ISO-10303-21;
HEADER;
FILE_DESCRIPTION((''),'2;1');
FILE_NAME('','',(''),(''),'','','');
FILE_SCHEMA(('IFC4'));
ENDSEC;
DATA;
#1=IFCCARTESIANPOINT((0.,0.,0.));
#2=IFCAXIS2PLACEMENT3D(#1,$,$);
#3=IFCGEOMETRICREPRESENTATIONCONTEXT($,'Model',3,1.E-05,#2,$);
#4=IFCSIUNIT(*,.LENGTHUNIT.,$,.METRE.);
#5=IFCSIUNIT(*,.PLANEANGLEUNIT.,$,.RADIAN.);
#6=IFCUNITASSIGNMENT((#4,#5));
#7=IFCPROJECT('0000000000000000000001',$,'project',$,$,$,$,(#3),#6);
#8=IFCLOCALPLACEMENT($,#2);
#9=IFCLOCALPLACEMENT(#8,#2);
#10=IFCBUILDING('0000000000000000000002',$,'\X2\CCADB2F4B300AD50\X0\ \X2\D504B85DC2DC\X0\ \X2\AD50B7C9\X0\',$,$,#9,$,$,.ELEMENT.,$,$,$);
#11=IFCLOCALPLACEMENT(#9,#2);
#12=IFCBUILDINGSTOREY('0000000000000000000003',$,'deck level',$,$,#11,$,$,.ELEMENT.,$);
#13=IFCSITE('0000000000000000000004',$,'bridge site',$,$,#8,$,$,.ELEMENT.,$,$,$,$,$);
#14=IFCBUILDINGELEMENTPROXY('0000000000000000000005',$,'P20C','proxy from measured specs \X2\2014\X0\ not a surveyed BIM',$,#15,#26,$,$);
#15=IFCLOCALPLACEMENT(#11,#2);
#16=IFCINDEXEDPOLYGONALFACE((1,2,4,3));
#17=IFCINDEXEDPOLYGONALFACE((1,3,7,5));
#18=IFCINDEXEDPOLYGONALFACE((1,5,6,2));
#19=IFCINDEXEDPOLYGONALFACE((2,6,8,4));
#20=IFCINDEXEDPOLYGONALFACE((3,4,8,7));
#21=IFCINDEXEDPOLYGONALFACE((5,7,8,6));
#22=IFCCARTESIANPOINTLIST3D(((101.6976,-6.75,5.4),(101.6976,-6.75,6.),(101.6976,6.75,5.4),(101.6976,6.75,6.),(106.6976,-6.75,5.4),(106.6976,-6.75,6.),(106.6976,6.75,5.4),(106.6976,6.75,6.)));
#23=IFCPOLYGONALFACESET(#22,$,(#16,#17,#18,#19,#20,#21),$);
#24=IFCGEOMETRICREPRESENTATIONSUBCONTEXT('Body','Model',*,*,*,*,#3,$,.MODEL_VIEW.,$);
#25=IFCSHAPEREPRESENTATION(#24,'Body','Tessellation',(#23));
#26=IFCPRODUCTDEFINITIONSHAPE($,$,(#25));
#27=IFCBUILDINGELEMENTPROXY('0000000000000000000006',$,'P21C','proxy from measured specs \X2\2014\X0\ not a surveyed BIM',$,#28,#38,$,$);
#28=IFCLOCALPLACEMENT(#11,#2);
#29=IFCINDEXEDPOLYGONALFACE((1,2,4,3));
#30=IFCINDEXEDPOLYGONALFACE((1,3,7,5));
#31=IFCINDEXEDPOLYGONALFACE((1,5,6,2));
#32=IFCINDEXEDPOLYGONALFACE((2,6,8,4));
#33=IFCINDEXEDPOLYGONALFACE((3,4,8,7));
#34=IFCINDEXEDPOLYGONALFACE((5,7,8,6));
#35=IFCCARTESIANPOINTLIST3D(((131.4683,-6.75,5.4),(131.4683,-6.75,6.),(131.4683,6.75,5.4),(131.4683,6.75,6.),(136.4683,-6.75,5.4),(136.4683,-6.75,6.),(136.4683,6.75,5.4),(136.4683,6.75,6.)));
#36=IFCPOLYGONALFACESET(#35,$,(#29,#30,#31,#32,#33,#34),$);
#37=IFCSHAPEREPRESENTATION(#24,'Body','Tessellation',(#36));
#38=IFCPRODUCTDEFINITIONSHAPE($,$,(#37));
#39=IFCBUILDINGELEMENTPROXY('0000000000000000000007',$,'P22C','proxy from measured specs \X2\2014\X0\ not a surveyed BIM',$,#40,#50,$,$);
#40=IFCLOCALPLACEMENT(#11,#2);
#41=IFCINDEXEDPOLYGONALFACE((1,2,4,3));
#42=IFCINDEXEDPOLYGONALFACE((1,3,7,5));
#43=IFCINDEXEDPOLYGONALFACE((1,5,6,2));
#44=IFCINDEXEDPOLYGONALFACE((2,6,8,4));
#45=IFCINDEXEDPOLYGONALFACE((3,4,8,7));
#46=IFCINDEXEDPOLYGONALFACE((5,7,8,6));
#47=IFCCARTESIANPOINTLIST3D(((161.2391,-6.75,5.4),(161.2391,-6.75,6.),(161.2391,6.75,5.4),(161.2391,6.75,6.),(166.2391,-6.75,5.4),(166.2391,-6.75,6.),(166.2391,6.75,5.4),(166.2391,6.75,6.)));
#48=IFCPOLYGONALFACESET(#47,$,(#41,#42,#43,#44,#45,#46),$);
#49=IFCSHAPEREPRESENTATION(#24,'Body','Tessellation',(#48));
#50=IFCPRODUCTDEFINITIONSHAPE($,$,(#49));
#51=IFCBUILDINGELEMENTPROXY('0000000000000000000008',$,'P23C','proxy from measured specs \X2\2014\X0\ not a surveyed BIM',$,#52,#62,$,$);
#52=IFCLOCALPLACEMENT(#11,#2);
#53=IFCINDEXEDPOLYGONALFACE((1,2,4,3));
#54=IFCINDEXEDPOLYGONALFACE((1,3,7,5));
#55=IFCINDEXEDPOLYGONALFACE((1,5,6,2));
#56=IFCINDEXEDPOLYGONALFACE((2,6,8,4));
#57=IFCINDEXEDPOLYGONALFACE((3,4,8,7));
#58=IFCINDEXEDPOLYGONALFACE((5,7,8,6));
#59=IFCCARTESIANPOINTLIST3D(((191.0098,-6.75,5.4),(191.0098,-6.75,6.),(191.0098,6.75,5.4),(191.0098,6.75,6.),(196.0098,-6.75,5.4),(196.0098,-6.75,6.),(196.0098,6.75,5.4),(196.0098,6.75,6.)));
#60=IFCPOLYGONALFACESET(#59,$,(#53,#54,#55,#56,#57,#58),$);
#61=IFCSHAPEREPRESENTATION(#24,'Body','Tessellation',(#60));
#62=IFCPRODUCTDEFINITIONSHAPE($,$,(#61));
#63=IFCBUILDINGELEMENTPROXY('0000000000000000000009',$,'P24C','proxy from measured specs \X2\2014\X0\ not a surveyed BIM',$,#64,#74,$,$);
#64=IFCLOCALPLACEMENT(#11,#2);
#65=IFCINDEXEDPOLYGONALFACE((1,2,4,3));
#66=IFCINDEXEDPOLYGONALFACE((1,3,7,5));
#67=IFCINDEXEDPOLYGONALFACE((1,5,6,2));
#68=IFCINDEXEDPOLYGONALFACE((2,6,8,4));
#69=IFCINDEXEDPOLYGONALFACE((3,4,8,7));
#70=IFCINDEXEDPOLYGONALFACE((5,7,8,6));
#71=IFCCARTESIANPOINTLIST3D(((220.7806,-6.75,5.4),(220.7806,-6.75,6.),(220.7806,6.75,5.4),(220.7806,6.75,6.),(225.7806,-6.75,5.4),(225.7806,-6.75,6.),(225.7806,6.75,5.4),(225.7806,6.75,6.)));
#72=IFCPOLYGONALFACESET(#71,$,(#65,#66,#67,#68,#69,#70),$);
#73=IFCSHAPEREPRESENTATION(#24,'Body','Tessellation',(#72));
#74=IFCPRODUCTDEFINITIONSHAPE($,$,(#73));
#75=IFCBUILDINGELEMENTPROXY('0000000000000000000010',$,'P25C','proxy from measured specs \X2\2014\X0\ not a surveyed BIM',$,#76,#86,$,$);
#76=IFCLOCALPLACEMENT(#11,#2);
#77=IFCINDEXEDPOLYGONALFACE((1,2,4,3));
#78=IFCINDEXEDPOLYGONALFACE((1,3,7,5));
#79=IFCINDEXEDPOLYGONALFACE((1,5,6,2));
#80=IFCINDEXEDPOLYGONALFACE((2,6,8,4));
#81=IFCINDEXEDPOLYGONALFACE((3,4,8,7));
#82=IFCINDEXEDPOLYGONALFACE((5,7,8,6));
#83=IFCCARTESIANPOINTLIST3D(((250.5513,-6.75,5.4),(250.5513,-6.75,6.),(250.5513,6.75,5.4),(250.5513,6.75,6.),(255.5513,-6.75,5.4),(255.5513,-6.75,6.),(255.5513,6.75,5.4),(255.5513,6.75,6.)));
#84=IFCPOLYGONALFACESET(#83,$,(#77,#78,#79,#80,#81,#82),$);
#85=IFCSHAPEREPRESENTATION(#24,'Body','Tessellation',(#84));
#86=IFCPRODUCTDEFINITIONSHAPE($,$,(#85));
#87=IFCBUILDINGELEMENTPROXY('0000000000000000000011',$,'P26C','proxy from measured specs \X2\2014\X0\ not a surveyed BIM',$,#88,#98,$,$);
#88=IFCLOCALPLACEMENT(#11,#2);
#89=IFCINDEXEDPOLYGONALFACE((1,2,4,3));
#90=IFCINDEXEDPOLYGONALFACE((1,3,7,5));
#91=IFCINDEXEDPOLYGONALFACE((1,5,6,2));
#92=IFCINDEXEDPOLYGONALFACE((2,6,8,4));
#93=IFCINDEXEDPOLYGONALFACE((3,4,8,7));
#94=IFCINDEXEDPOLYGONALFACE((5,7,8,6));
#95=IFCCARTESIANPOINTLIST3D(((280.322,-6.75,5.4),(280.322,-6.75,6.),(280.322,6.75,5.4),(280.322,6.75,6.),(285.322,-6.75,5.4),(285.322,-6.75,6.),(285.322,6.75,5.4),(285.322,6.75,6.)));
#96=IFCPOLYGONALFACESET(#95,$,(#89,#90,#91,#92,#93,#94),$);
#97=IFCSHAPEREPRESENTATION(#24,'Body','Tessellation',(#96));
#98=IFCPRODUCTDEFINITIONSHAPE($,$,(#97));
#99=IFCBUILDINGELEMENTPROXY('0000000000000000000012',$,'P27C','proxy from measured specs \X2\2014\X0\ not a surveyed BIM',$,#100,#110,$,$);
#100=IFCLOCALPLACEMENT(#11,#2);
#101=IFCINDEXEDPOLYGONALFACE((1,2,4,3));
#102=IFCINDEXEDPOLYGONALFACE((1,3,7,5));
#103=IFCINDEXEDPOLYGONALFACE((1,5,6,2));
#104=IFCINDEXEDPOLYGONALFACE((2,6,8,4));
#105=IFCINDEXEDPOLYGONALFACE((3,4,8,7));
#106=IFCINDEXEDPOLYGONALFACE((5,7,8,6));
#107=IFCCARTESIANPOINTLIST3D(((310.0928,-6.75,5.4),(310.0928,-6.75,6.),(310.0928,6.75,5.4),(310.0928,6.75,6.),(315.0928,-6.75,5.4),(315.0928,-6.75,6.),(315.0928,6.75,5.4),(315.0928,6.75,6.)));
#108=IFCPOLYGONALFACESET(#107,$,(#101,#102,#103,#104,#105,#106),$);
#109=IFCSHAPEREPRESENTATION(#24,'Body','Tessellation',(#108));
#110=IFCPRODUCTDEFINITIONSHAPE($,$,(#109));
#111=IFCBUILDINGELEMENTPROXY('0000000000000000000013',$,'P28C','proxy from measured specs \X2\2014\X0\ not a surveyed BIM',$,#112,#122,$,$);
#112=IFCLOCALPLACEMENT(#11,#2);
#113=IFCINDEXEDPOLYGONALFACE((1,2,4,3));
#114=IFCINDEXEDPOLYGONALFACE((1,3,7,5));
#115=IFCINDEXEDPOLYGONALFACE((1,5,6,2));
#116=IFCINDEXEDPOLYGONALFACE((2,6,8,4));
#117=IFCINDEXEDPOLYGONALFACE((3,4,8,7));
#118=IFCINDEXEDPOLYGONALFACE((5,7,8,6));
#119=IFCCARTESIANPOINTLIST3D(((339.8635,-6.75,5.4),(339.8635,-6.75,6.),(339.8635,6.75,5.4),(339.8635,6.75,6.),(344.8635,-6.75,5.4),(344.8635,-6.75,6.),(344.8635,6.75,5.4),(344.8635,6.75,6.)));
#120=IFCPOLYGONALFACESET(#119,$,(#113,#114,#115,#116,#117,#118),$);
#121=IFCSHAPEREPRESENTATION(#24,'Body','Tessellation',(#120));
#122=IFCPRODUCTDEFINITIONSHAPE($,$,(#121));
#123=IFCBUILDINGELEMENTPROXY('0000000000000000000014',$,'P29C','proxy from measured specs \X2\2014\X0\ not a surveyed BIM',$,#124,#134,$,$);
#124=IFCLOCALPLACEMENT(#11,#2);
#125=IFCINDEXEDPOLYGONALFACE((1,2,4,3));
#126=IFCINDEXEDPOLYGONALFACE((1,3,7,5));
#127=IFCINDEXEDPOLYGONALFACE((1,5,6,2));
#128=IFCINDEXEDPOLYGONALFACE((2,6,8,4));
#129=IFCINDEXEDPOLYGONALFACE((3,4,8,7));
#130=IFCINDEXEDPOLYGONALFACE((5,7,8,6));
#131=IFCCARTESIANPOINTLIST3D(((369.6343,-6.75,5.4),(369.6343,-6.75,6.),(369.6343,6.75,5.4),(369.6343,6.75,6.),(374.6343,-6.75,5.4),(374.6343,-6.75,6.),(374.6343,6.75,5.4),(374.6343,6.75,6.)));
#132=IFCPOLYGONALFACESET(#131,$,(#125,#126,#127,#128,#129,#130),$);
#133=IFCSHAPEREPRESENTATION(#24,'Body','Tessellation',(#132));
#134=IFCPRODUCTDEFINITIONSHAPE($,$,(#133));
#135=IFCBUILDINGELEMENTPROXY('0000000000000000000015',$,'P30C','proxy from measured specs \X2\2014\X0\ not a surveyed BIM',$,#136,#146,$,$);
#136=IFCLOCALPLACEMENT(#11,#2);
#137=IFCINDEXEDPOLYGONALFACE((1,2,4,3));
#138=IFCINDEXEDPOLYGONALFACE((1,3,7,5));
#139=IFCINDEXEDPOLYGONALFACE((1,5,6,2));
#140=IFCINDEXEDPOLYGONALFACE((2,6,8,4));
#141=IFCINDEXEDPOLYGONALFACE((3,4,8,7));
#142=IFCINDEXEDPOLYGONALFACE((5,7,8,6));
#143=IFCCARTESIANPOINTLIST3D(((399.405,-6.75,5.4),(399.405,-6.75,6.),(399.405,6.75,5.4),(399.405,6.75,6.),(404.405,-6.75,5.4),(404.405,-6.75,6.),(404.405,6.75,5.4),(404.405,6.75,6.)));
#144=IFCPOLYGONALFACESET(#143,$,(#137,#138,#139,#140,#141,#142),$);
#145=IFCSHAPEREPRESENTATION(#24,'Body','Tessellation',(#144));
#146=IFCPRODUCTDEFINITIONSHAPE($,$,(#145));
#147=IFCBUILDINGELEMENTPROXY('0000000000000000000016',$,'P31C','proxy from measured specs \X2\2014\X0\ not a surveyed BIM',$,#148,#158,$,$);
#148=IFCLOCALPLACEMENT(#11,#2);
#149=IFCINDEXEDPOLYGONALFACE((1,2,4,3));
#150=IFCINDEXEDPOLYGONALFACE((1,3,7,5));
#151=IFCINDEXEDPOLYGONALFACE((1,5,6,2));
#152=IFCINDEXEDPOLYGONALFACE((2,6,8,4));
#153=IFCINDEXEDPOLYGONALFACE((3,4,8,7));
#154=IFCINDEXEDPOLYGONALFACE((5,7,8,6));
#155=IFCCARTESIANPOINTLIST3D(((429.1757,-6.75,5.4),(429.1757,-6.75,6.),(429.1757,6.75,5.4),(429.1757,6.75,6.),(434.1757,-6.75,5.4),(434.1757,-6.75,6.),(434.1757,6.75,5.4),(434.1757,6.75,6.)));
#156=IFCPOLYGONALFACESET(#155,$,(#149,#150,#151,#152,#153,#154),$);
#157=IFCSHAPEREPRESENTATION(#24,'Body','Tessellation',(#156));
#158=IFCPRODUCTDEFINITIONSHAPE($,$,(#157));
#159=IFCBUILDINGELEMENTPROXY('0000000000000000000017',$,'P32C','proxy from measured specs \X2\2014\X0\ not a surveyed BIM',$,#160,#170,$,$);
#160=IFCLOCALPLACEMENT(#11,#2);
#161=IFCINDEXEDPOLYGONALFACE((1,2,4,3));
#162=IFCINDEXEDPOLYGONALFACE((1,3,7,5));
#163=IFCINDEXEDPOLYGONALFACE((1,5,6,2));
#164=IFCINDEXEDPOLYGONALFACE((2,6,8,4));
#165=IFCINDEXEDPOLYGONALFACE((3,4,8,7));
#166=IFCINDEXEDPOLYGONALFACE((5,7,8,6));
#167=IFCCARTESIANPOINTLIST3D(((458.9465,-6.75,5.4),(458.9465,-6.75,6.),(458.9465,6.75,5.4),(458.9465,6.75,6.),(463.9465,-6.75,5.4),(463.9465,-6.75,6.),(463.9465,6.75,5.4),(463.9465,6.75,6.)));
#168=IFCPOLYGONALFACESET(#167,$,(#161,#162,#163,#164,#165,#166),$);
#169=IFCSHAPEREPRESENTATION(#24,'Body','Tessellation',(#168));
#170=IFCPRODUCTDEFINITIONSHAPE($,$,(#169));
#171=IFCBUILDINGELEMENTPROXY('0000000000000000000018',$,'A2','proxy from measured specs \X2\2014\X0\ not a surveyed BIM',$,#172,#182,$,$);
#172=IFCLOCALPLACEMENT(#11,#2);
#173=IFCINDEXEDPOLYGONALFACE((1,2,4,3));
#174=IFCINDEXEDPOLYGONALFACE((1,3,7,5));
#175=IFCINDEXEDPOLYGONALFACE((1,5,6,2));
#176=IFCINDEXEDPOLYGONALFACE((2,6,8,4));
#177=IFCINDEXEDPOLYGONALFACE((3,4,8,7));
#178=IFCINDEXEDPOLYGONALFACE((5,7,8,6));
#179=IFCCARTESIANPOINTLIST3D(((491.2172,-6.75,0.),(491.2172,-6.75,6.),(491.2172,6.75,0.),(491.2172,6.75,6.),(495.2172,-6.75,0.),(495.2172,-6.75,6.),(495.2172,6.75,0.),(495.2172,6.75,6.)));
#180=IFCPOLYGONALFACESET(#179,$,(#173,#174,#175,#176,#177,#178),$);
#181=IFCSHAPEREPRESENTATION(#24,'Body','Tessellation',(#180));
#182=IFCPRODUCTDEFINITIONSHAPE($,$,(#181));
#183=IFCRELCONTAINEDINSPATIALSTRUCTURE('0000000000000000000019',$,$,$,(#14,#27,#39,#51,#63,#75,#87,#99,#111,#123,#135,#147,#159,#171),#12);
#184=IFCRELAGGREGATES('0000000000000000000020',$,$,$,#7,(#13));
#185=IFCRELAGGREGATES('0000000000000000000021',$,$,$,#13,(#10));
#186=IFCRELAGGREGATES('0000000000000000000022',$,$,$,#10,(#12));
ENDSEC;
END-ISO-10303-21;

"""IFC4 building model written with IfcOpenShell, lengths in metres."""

from ifc_helpers import new_model, si_unit, frame, origin, origin_2d, place, context, subcontext, project, spatial, rectangle, extrude, element, save


model = new_model("IFC4")

# Units and contexts
model_context = context("Model", 3, precision=1e-05, world=origin())
body_context = subcontext(model_context, "Body", "Model", "MODEL_VIEW")
ifc_project = project(units=[si_unit("LENGTHUNIT", "METRE"), si_unit("PLANEANGLEUNIT", "RADIAN")], contexts=[model_context])

# Site, building, storey
site_placement = place(None, origin())
site = spatial("IfcSite", under=ifc_project, at=site_placement, Name="bridge site", CompositionType="ELEMENT")
building_placement = place(site_placement, origin())
building = spatial("IfcBuilding", under=site, at=building_placement, Name="청담대교 프록시 교량", CompositionType="ELEMENT")
storey_placement = place(building_placement, origin())
storey = spatial("IfcBuildingStorey", under=building, at=storey_placement, Name="deck level", CompositionType="ELEMENT")

# Building element proxies
for number, where, name in (
    (1, (104.1976, 0.0, 5.4), "P20C"),
    (2, (133.9683, 0.0, 5.4), "P21C"),
    (3, (163.7391, 0.0, 5.4), "P22C"),
    (4, (193.5098, 0.0, 5.4), "P23C"),
    (5, (223.2806, 0.0, 5.4), "P24C"),
    (6, (253.0513, 0.0, 5.4), "P25C"),
    (7, (282.822, 0.0, 5.4), "P26C"),
    (8, (312.5928, 0.0, 5.4), "P27C"),
    (9, (342.3635, 0.0, 5.4), "P28C"),
    (10, (372.1343, 0.0, 5.4), "P29C"),
    (11, (401.905, 0.0, 5.4), "P30C"),
    (12, (431.6757, 0.0, 5.4), "P31C"),
    (13, (461.4465, 0.0, 5.4), "P32C"),
):
    element("IfcBuildingElementProxy", number, at=place(storey_placement, frame(where)), inside=storey, Name=name, Description="proxy from measured specs — not a surveyed BIM", context=body_context, shape_type="SweptSolid", body=[
        extrude(rectangle(XDim=5.0, YDim=13.5, at=origin_2d()), origin(), (0.0, 0.0, 1.0), 0.6),
    ])
proxy_placement = place(storey_placement, frame((493.2172, 0.0, 0.0)))
element("IfcBuildingElementProxy", 14, at=proxy_placement, inside=storey, Name="A2", Description="proxy from measured specs — not a surveyed BIM", context=body_context, shape_type="SweptSolid", body=[
    extrude(rectangle(XDim=4.0, YDim=13.5, at=origin_2d()), origin(), (0.0, 0.0, 1.0), 6.0),
])

save(model, "model.ifc")
